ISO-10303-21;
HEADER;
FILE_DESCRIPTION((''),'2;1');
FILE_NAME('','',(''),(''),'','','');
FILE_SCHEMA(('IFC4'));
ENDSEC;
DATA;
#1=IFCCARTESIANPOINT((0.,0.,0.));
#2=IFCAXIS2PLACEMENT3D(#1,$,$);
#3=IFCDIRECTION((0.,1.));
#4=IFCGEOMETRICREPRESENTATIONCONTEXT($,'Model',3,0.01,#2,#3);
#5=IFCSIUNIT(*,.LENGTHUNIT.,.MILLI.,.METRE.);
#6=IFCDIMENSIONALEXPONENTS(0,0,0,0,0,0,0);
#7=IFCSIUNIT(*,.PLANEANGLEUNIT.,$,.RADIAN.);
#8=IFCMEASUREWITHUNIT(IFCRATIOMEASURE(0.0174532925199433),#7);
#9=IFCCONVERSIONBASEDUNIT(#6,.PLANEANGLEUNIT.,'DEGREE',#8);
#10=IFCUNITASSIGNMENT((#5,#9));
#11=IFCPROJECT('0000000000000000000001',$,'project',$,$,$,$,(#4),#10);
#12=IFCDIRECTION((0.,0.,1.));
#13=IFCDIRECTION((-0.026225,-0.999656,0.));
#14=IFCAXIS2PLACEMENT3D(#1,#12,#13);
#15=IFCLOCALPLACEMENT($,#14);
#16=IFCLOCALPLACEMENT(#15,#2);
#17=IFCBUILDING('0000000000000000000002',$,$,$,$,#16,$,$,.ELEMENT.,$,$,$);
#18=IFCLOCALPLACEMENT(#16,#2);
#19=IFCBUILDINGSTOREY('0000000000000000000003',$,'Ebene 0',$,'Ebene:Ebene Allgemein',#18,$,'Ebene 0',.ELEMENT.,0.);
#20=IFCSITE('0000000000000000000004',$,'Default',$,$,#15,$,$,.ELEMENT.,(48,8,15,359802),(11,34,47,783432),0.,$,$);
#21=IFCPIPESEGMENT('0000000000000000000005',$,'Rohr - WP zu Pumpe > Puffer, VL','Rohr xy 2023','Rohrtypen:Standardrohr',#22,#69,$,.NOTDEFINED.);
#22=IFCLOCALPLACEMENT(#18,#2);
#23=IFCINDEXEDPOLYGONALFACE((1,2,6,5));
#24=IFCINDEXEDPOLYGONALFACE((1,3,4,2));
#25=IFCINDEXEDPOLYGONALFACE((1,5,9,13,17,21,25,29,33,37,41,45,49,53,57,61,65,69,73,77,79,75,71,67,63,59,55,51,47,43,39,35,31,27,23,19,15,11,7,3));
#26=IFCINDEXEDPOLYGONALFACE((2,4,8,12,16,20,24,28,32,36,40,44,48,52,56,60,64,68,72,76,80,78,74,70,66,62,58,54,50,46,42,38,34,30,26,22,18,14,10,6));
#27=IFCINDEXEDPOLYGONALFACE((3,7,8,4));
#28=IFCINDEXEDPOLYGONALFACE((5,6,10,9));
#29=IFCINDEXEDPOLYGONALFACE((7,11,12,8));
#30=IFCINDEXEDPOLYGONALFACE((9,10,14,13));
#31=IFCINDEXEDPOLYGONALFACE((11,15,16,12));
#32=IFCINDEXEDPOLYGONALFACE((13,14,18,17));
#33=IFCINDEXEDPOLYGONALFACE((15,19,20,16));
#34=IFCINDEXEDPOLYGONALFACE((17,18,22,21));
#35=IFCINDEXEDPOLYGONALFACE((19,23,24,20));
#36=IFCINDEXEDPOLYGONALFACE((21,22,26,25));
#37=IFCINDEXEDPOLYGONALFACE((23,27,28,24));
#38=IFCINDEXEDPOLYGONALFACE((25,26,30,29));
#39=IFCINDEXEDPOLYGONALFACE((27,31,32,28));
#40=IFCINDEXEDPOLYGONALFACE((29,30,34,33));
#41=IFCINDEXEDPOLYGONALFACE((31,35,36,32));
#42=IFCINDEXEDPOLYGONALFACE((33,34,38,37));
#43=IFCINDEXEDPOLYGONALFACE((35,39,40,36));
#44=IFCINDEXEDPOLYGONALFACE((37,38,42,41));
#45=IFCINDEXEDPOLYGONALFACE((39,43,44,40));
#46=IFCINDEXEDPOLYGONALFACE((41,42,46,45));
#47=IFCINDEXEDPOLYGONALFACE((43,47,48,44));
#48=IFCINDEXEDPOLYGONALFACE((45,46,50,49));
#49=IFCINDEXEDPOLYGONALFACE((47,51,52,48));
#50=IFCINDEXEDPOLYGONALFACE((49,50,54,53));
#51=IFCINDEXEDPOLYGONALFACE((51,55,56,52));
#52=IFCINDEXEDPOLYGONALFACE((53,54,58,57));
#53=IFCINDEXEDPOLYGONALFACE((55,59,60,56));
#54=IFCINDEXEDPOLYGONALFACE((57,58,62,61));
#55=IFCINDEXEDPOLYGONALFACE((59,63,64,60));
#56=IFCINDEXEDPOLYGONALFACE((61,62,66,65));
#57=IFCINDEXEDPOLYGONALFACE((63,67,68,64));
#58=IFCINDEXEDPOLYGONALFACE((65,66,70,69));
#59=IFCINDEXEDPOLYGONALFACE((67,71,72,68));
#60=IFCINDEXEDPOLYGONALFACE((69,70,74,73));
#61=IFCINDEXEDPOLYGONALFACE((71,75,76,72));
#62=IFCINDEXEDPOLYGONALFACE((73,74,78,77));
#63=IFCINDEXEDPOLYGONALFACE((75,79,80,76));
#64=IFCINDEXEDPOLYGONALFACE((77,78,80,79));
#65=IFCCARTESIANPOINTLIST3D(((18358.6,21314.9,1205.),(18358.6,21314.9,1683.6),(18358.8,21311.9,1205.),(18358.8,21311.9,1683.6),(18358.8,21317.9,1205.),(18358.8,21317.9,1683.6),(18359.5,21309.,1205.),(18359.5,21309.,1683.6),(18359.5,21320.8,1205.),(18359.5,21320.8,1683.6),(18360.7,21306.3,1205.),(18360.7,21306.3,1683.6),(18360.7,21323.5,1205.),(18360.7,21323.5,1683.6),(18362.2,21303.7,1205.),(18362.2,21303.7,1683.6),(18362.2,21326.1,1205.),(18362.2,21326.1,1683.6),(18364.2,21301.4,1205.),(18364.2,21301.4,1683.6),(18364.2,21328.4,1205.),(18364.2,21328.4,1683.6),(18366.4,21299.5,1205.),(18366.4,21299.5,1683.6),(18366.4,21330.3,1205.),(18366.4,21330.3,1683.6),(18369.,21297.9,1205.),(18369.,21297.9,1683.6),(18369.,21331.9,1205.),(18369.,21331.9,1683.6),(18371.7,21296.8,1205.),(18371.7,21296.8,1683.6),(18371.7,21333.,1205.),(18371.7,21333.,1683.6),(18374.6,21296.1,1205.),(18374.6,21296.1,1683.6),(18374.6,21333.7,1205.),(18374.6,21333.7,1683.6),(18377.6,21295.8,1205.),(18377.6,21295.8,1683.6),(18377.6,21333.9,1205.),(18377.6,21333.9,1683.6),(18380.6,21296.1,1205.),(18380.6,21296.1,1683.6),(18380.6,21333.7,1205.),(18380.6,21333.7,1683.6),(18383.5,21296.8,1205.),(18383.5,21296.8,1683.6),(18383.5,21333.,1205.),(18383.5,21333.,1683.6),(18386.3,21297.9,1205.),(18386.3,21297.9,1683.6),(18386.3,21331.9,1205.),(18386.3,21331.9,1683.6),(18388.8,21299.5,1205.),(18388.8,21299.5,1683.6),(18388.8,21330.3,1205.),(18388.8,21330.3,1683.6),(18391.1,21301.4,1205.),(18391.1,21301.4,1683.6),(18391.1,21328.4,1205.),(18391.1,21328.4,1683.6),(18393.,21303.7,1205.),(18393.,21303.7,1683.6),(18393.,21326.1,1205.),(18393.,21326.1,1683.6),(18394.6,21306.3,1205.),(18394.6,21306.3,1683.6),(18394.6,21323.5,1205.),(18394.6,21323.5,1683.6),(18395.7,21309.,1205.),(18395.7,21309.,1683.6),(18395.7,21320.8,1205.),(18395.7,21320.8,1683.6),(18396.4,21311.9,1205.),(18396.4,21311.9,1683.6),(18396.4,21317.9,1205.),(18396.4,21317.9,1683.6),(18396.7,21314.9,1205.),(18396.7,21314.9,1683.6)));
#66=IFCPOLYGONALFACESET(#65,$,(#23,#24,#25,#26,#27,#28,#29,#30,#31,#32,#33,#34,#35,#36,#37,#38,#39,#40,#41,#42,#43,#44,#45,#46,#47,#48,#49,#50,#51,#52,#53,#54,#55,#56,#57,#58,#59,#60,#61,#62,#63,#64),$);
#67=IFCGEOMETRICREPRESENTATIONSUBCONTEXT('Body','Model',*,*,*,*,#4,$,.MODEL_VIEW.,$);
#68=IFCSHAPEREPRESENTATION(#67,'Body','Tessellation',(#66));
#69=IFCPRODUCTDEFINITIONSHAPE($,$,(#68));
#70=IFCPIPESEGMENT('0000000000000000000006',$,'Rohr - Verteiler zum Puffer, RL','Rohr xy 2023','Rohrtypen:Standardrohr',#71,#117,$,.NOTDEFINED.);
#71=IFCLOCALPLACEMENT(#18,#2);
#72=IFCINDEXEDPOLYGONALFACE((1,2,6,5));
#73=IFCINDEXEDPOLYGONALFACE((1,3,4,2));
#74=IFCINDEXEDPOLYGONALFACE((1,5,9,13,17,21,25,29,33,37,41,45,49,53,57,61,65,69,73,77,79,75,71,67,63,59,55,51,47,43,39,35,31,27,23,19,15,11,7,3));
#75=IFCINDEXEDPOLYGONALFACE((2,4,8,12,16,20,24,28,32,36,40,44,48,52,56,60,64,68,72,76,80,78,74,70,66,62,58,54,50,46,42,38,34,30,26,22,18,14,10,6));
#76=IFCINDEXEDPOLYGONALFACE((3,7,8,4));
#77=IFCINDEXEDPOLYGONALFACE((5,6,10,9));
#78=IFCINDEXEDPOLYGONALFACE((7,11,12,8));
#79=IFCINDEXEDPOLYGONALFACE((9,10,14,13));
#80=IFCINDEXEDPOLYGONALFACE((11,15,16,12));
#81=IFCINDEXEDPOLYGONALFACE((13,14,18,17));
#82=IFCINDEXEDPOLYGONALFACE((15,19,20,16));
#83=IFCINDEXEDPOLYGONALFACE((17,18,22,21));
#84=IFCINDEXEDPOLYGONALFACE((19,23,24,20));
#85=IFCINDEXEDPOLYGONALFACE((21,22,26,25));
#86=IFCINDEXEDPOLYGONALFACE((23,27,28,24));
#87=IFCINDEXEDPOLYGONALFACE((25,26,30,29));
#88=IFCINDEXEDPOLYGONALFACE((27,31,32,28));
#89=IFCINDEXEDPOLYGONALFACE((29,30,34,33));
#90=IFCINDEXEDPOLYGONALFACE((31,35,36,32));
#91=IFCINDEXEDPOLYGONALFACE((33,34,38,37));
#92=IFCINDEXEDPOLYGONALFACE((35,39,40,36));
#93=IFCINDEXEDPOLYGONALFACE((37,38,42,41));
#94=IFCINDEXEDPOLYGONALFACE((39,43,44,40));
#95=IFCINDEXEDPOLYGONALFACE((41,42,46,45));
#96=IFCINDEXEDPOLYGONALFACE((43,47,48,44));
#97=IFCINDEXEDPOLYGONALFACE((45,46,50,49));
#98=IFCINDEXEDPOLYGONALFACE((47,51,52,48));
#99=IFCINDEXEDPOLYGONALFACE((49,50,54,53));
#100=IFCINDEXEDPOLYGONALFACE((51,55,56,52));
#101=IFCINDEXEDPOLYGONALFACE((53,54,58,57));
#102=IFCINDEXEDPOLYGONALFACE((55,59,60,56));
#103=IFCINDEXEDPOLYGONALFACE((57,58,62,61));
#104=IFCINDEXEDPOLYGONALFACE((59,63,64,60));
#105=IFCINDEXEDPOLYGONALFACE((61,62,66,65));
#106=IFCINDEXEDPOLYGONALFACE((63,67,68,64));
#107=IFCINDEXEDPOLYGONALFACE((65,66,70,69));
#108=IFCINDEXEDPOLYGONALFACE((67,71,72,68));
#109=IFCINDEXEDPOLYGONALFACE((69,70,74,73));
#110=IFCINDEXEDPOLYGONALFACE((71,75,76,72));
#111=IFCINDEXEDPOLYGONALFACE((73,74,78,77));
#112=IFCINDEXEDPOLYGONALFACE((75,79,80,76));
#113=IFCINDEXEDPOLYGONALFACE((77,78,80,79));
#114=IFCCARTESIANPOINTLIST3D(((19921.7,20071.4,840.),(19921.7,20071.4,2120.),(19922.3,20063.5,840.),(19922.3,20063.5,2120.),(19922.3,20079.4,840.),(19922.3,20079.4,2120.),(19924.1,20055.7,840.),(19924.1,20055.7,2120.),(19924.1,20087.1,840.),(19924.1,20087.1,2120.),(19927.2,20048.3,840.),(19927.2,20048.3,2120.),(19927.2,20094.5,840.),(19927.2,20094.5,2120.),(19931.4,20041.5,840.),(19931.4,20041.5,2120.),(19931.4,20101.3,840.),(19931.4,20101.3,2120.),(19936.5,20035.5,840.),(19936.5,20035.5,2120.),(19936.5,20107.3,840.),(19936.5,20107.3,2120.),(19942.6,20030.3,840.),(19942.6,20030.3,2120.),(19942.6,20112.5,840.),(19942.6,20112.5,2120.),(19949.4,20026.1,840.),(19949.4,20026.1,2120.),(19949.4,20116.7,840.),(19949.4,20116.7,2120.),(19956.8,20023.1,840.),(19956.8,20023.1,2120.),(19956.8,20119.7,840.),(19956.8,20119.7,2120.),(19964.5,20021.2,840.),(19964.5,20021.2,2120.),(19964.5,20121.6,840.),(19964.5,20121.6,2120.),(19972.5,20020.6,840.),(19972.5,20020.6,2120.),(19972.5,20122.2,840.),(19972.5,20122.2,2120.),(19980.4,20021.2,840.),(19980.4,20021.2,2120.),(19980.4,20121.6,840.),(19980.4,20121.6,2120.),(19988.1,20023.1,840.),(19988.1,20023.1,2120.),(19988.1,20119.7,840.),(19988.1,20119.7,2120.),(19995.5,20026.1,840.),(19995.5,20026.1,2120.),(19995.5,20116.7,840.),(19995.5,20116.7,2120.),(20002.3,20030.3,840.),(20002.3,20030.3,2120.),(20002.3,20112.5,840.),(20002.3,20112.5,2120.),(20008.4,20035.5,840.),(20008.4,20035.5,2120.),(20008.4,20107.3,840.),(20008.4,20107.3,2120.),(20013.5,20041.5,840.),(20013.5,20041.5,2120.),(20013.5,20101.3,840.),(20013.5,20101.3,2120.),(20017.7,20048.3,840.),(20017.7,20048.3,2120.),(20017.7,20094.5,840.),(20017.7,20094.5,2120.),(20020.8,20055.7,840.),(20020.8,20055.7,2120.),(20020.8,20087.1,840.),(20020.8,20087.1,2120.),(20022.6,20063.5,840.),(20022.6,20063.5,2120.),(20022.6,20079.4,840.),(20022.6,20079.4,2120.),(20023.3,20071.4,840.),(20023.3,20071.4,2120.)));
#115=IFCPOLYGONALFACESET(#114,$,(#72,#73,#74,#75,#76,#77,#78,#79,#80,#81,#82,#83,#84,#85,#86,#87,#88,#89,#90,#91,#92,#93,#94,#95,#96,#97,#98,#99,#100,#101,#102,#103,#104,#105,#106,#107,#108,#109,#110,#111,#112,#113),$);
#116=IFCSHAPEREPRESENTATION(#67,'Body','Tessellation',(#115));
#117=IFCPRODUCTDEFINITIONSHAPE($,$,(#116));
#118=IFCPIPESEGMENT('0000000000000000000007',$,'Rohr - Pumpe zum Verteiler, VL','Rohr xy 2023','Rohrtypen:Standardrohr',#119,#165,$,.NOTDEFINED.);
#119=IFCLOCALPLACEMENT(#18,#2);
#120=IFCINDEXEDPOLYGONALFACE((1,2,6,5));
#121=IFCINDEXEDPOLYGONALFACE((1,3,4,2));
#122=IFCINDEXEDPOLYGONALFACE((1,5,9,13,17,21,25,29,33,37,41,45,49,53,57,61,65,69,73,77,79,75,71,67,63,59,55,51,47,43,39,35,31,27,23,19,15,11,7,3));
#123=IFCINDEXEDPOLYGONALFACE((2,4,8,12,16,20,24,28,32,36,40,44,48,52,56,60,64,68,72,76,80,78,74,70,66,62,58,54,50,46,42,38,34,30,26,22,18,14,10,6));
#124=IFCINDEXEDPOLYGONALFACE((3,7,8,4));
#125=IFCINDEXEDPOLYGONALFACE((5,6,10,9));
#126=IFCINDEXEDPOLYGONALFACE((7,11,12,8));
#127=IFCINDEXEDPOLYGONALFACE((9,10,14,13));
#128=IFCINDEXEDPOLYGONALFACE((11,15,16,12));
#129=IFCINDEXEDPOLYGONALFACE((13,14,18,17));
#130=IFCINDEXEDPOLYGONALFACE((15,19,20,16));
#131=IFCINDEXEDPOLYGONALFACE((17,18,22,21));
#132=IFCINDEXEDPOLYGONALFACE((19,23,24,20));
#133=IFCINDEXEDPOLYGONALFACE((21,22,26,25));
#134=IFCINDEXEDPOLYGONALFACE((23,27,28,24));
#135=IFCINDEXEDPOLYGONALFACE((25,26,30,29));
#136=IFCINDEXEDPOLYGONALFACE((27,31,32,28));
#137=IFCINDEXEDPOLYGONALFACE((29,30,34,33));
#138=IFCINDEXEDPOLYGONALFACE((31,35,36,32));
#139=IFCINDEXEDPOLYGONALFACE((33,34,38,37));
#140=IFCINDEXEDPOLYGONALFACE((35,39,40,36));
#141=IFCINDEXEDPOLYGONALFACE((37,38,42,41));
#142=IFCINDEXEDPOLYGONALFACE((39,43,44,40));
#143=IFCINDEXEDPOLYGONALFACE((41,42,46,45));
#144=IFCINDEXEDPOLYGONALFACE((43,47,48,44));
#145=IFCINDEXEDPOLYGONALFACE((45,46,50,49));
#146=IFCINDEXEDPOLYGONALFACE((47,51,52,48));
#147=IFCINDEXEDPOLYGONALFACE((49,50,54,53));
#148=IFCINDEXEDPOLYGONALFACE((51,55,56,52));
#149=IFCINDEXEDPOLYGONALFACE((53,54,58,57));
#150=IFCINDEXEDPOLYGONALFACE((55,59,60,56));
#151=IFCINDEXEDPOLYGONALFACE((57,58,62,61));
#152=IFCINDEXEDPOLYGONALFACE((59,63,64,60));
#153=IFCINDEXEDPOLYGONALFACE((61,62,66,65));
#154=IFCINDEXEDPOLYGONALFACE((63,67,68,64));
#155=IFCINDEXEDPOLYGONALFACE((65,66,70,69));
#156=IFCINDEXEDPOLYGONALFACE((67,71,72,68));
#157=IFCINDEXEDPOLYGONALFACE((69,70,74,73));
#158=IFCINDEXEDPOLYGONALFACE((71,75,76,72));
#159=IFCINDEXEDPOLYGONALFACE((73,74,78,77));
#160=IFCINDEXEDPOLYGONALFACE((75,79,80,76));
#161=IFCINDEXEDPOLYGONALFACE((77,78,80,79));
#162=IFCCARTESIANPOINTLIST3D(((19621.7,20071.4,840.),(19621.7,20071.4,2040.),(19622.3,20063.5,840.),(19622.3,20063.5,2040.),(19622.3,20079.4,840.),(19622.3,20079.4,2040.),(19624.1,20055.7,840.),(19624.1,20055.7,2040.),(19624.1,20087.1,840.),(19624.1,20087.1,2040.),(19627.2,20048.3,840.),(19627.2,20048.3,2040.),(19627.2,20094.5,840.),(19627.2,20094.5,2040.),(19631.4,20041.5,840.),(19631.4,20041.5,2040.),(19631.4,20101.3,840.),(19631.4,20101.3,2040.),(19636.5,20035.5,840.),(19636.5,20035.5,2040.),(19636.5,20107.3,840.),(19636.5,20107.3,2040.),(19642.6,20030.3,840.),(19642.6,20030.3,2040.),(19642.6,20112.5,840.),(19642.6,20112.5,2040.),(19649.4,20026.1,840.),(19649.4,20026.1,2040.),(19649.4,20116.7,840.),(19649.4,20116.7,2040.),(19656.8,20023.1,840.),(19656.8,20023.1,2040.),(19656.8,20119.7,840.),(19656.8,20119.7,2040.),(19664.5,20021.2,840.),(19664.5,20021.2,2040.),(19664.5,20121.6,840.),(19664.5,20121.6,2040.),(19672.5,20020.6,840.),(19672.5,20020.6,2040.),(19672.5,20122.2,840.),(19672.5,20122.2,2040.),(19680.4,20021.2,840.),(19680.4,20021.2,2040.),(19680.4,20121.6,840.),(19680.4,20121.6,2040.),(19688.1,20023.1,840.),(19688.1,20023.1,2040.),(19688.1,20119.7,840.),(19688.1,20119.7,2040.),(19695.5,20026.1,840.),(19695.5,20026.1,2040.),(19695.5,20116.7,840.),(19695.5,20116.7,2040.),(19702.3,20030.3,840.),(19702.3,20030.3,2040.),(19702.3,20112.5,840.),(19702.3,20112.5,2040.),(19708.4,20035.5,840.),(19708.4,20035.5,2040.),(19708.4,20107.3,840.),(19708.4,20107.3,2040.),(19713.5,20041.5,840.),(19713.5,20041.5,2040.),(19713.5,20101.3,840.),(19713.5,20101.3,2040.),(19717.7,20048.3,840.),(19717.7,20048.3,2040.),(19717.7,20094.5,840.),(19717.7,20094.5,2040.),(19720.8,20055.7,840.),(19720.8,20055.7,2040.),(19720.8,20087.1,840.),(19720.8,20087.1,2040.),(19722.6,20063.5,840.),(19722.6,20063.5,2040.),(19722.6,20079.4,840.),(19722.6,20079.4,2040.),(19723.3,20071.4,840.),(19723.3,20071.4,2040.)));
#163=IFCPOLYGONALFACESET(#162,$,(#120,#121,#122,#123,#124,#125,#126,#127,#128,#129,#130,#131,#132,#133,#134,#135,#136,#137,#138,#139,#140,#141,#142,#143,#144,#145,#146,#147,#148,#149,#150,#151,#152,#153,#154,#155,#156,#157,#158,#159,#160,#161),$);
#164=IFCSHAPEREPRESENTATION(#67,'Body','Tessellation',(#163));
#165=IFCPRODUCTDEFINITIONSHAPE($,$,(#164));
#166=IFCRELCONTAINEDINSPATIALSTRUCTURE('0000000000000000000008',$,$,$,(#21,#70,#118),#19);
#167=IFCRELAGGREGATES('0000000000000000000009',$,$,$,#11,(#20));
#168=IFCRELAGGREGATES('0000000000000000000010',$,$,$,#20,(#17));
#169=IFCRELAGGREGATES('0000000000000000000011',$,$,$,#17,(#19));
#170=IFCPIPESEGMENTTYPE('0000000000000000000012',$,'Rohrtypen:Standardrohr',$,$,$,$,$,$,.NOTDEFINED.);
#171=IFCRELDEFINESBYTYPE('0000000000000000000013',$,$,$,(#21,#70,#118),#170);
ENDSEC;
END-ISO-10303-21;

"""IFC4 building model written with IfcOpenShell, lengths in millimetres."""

from ifc_helpers import new_model, entity, si_unit, converted_unit, direction, frame, origin, place, context, subcontext, project, spatial, indexed_curve, outline, extrude, type_object, element, save


model = new_model("IFC4")

# Units and contexts
model_context = context("Model", 3, precision=0.01, world=origin(), true_north=direction((0.0, 1.0)))
body_context = subcontext(model_context, "Body", "Model", "MODEL_VIEW")
ifc_project = project(units=[si_unit("LENGTHUNIT", "METRE", prefix="MILLI"), converted_unit("PLANEANGLEUNIT", "DEGREE", entity("IfcRatioMeasure", 0.0174532925199433), si_unit("PLANEANGLEUNIT", "RADIAN"), dimensions=[0, 0, 0, 0, 0, 0, 0])], contexts=[model_context])

# Site, building, storey
site_placement = place(None, frame((0.0, 0.0, 0.0), z_axis=(0.0, 0.0, 1.0), x_axis=(-0.026225, -0.999656, 0.0)))
site = spatial("IfcSite", under=ifc_project, at=site_placement, Name="Default", CompositionType="ELEMENT", RefLatitude=(48, 8, 15, 359802), RefLongitude=(11, 34, 47, 783432), RefElevation=0.0)
building_placement = place(site_placement, origin())
building = spatial("IfcBuilding", under=site, at=building_placement, CompositionType="ELEMENT")
storey_placement = place(building_placement, origin())
storey = spatial("IfcBuildingStorey", under=building, at=storey_placement, Name="Ebene 0", ObjectType="Ebene:Ebene Allgemein", LongName="Ebene 0", CompositionType="ELEMENT", Elevation=0.0)

# Pipe segments
pipe_segment_type = type_object("IfcPipeSegmentType", Name="Rohrtypen:Standardrohr", PredefinedType="NOTDEFINED")
pipe_segment_1_placement = place(storey_placement, origin())
element("IfcPipeSegment", 1, at=pipe_segment_1_placement, inside=storey, type_object=pipe_segment_type, Name="Rohr - WP zu Pumpe > Puffer, VL", Description="Rohr xy 2023", ObjectType="Rohrtypen:Standardrohr", PredefinedType="NOTDEFINED", context=body_context, shape_type="SweptSolid", body=[
    extrude(outline(indexed_curve([(19.1, 0.0), (18.8, 3.0), (18.1, 5.9), (17.0, 8.6), (15.4, 11.2), (13.5, 13.5), (11.2, 15.4), (8.6, 17.0), (5.9, 18.1), (3.0, 18.8), (0.0, 19.1), (-3.0, 18.8), (-5.9, 18.1), (-8.6, 17.0), (-11.2, 15.4), (-13.5, 13.5), (-15.4, 11.2), (-17.0, 8.6), (-18.1, 5.9), (-18.8, 3.0), (-19.1, 0.0), (-18.8, -3.0), (-18.1, -5.9), (-17.0, -8.6), (-15.4, -11.2), (-13.5, -13.5), (-11.2, -15.4), (-8.6, -17.0), (-5.9, -18.1), (-3.0, -18.8), (0.0, -19.1), (3.0, -18.8), (5.9, -18.1), (8.6, -17.0), (11.2, -15.4), (13.5, -13.5), (15.4, -11.2), (17.0, -8.6), (18.1, -5.9), (18.8, -3.0), (19.1, 0.0)], self_intersect=False)), frame((18377.6, 21314.9, 1205.0), z_axis=(0.0, 0.0, 1.0), x_axis=(-1.0, 0.0, 0.0)), (0.0, 0.0, 1.0), 478.6),
])
pipe_segment_2_placement = place(storey_placement, origin())
element("IfcPipeSegment", 2, at=pipe_segment_2_placement, inside=storey, type_object=pipe_segment_type, Name="Rohr - Verteiler zum Puffer, RL", Description="Rohr xy 2023", ObjectType="Rohrtypen:Standardrohr", PredefinedType="NOTDEFINED", context=body_context, shape_type="SweptSolid", body=[
    extrude(outline(indexed_curve([(50.8, 0.0), (50.2, 7.9), (48.3, 15.7), (45.3, 23.1), (41.1, 29.9), (35.9, 35.9), (29.9, 41.1), (23.1, 45.3), (15.7, 48.3), (7.9, 50.2), (0.0, 50.8), (-7.9, 50.2), (-15.7, 48.3), (-23.1, 45.3), (-29.9, 41.1), (-35.9, 35.9), (-41.1, 29.9), (-45.3, 23.1), (-48.3, 15.7), (-50.2, 7.9), (-50.8, 0.0), (-50.2, -7.9), (-48.3, -15.7), (-45.3, -23.1), (-41.1, -29.9), (-35.9, -35.9), (-29.9, -41.1), (-23.1, -45.3), (-15.7, -48.3), (-7.9, -50.2), (0.0, -50.8), (7.9, -50.2), (15.7, -48.3), (23.1, -45.3), (29.9, -41.1), (35.9, -35.9), (41.1, -29.9), (45.3, -23.1), (48.3, -15.7), (50.2, -7.9), (50.8, 0.0)], self_intersect=False)), frame((19972.5, 20071.4, 840.0), z_axis=(0.0, 0.0, 1.0), x_axis=(-1.0, 0.0, 0.0)), (0.0, 0.0, 1.0), 1280.0),
])
pipe_segment_3_placement = place(storey_placement, origin())
element("IfcPipeSegment", 3, at=pipe_segment_3_placement, inside=storey, type_object=pipe_segment_type, Name="Rohr - Pumpe zum Verteiler, VL", Description="Rohr xy 2023", ObjectType="Rohrtypen:Standardrohr", PredefinedType="NOTDEFINED", context=body_context, shape_type="SweptSolid", body=[
    extrude(outline(indexed_curve([(50.8, 0.0), (50.2, 7.9), (48.3, 15.7), (45.3, 23.1), (41.1, 29.9), (35.9, 35.9), (29.9, 41.1), (23.1, 45.3), (15.7, 48.3), (7.9, 50.2), (0.0, 50.8), (-7.9, 50.2), (-15.7, 48.3), (-23.1, 45.3), (-29.9, 41.1), (-35.9, 35.9), (-41.1, 29.9), (-45.3, 23.1), (-48.3, 15.7), (-50.2, 7.9), (-50.8, 0.0), (-50.2, -7.9), (-48.3, -15.7), (-45.3, -23.1), (-41.1, -29.9), (-35.9, -35.9), (-29.9, -41.1), (-23.1, -45.3), (-15.7, -48.3), (-7.9, -50.2), (0.0, -50.8), (7.9, -50.2), (15.7, -48.3), (23.1, -45.3), (29.9, -41.1), (35.9, -35.9), (41.1, -29.9), (45.3, -23.1), (48.3, -15.7), (50.2, -7.9), (50.8, 0.0)], self_intersect=False)), frame((19672.5, 20071.4, 840.0), z_axis=(0.0, 0.0, 1.0), x_axis=(-1.0, 0.0, 0.0)), (0.0, 0.0, 1.0), 1200.0),
])

save(model, "model.ifc")
